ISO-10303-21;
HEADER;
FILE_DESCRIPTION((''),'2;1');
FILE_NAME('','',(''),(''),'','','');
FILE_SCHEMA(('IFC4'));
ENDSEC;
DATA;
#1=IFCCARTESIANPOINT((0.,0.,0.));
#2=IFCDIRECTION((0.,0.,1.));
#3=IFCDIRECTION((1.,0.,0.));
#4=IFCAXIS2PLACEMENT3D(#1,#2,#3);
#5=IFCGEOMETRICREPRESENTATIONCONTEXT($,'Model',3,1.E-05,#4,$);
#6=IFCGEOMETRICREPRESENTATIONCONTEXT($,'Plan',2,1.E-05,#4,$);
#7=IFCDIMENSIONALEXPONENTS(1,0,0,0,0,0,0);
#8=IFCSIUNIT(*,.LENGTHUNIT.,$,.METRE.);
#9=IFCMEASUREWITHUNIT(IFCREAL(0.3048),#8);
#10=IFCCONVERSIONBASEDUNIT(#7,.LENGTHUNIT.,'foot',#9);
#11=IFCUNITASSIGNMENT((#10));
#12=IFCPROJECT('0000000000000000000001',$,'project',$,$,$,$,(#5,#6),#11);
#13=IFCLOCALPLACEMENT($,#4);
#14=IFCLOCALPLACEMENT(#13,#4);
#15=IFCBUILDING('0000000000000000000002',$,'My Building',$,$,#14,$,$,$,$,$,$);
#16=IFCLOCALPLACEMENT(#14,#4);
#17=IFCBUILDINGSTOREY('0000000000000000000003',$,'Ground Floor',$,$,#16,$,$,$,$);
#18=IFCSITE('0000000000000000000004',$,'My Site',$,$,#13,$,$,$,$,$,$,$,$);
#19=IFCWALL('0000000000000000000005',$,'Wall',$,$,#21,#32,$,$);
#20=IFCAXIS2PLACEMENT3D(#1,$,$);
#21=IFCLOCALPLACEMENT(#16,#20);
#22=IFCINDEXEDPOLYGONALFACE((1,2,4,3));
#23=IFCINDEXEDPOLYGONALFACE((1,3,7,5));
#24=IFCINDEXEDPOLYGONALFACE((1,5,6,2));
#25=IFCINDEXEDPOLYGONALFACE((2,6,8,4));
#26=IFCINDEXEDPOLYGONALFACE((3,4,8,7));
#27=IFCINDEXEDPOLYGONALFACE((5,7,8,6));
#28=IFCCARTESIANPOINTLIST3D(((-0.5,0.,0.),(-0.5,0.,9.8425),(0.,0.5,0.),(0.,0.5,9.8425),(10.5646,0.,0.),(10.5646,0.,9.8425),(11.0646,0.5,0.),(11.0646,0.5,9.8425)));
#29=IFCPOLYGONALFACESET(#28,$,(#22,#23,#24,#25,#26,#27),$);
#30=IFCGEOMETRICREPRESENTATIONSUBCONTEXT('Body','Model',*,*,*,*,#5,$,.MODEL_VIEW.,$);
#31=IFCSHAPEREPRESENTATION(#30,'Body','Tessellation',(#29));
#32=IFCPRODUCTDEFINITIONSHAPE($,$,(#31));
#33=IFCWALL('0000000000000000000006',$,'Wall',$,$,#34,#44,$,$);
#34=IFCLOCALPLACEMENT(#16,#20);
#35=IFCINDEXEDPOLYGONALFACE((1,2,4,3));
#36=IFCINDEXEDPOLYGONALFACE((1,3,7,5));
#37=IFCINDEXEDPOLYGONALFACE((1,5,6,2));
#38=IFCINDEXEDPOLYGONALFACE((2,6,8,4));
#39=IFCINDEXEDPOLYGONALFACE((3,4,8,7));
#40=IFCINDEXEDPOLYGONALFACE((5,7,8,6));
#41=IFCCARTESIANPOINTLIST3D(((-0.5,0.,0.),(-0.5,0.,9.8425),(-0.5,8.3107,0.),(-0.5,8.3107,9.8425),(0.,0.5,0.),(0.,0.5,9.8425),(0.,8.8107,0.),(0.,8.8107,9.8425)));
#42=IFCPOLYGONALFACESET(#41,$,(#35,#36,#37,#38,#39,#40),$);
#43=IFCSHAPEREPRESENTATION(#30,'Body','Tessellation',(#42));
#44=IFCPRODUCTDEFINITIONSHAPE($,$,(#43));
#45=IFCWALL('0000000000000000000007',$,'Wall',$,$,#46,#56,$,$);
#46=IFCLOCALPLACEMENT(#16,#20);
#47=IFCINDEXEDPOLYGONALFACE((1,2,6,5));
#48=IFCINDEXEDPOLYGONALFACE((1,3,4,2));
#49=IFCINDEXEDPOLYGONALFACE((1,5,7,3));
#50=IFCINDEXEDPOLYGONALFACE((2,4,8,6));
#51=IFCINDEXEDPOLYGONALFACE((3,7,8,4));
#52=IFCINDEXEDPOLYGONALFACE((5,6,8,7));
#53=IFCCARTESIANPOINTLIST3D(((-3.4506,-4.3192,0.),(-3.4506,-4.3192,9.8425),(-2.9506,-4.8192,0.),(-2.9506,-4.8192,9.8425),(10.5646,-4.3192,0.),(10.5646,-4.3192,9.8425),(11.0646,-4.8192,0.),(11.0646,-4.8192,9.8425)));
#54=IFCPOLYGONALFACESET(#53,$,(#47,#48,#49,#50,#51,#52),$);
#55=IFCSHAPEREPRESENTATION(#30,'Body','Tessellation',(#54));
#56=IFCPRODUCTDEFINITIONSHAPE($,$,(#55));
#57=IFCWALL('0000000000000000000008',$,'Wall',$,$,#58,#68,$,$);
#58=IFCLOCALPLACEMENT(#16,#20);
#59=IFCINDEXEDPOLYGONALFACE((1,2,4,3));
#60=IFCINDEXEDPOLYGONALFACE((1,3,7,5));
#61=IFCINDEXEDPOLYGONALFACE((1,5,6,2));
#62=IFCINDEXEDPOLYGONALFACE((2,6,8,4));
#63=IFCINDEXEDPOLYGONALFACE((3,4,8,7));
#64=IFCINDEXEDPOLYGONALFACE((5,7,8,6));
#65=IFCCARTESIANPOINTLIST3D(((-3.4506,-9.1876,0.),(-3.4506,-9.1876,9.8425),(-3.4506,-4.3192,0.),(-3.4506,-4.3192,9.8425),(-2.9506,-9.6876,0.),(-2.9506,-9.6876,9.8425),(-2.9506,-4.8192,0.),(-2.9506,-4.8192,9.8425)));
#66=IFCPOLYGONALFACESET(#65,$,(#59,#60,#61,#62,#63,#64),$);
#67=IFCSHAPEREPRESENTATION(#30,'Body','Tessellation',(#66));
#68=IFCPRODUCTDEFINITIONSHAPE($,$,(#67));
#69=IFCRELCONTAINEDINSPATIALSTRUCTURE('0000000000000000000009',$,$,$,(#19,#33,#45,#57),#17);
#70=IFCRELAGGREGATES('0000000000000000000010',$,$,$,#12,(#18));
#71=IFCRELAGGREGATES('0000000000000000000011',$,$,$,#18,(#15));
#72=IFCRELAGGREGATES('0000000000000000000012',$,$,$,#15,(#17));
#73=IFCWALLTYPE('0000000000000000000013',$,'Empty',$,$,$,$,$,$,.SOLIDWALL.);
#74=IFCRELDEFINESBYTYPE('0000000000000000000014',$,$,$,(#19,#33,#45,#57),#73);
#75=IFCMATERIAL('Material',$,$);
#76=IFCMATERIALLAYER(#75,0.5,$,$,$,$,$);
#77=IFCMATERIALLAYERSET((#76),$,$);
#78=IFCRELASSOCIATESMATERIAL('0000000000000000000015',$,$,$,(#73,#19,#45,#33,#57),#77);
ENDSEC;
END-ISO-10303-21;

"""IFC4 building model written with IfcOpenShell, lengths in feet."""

from ifc_helpers import new_model, entity, si_unit, converted_unit, frame, origin_with_axes, place, context, subcontext, project, spatial, polyline, outline, extrude, material, layer, layer_set, layer_usage, type_object, element, save


model = new_model("IFC4")

# Units and contexts
model_context = context("Model", 3, precision=1e-05, world=origin_with_axes())
plan_context = context("Plan", 2, precision=1e-05, world=origin_with_axes())
body_context = subcontext(model_context, "Body", "Model", "MODEL_VIEW")
ifc_project = project(units=[converted_unit("LENGTHUNIT", "foot", entity("IfcReal", 0.3048), si_unit("LENGTHUNIT", "METRE"), dimensions=[1, 0, 0, 0, 0, 0, 0])], contexts=[model_context, plan_context])

# Site, building, storey
site_placement = place(None, origin_with_axes())
site = spatial("IfcSite", under=ifc_project, at=site_placement, Name="My Site")
building_placement = place(site_placement, origin_with_axes())
building = spatial("IfcBuilding", under=site, at=building_placement, Name="My Building")
storey_placement = place(building_placement, origin_with_axes())
storey = spatial("IfcBuildingStorey", under=building, at=storey_placement, Name="Ground Floor")

# Walls
ifc_material = material(Name="Material")
ifc_layer = layer(ifc_material, 0.5)
ifc_layer_set = layer_set([ifc_layer])
ifc_layer_usage_1 = layer_usage(ifc_layer_set, "AXIS2", "POSITIVE", 0.0)
wall_type = type_object("IfcWallType", Name="Empty", PredefinedType="SOLIDWALL", material=ifc_layer_set)
wall_1_placement = place(storey_placement, frame((-0.5, 0.0, 0.0), z_axis=(0.0, 0.0, 1.0), x_axis=(1.0, 0.0, 0.0)))
element("IfcWall", 1, at=wall_1_placement, inside=storey, type_object=wall_type, material=ifc_layer_usage_1, Name="Wall", context=body_context, shape_type="SweptSolid", body=[
    extrude(outline(polyline([(-4.2655, -3.9119), (-3.5584, -3.9119), (4.2655, 3.9119), (3.5584, 3.9119), (-4.2655, -3.9119)])), frame((5.7823, 0.25, 0.0), z_axis=(0.0, 0.0, -1.0), x_axis=(0.707107, 0.707107, 0.0)), (0.0, 0.0, -1.0), 9.8425),
])
ifc_layer_usage_2 = layer_usage(ifc_layer_set, "AXIS2", "POSITIVE", 0.0)
wall_2_placement = place(storey_placement, frame((0.0, 0.0, 0.0), z_axis=(0.0, 0.0, 1.0), x_axis=(0.0, 1.0, 0.0)))
element("IfcWall", 2, at=wall_2_placement, inside=storey, type_object=wall_type, material=ifc_layer_usage_2, Name="Wall", context=body_context, shape_type="SweptSolid", body=[
    extrude(outline(polyline([(2.5847, -2.9383), (3.2918, -2.9383), (-2.5847, 2.9383), (-3.2918, 2.9383), (2.5847, -2.9383)])), frame((4.4054, 0.25, 0.0), z_axis=(0.0, 0.0, -1.0), x_axis=(-0.707107, 0.707107, 0.0)), (0.0, 0.0, -1.0), 9.8425),
])
wall_3_placement = place(storey_placement, frame((-3.4506, -4.8192, 0.0), z_axis=(0.0, 0.0, 1.0), x_axis=(1.0, 0.0, 0.0)))
element("IfcWall", 3, at=wall_3_placement, inside=storey, type_object=wall_type, material=ifc_layer_usage_1, Name="Wall", context=body_context, shape_type="SweptSolid", body=[
    extrude(outline(polyline([(4.6015, -4.9551), (5.3086, -4.9551), (-4.6015, 4.9551), (-5.3086, 4.9551), (4.6015, -4.9551)])), frame((7.2576, 0.25, 0.0), z_axis=(0.0, 0.0, -1.0), x_axis=(-0.707107, 0.707107, 0.0)), (0.0, 0.0, -1.0), 9.8425),
])
wall_4_placement = place(storey_placement, frame((-2.9506, -9.6876, 0.0), z_axis=(0.0, 0.0, 1.0), x_axis=(0.0, 1.0, 0.0)))
element("IfcWall", 4, at=wall_4_placement, inside=storey, type_object=wall_type, material=ifc_layer_usage_2, Name="Wall", context=body_context, shape_type="SweptSolid", body=[
    extrude(outline(polyline([(-2.0748, -1.7212), (-1.3677, -1.7212), (2.0748, 1.7212), (1.3677, 1.7212), (-2.0748, -1.7212)])), frame((2.6842, 0.25, 0.0), z_axis=(0.0, 0.0, -1.0), x_axis=(0.707107, 0.707107, 0.0)), (0.0, 0.0, -1.0), 9.8425),
])

save(model, "model.ifc")
